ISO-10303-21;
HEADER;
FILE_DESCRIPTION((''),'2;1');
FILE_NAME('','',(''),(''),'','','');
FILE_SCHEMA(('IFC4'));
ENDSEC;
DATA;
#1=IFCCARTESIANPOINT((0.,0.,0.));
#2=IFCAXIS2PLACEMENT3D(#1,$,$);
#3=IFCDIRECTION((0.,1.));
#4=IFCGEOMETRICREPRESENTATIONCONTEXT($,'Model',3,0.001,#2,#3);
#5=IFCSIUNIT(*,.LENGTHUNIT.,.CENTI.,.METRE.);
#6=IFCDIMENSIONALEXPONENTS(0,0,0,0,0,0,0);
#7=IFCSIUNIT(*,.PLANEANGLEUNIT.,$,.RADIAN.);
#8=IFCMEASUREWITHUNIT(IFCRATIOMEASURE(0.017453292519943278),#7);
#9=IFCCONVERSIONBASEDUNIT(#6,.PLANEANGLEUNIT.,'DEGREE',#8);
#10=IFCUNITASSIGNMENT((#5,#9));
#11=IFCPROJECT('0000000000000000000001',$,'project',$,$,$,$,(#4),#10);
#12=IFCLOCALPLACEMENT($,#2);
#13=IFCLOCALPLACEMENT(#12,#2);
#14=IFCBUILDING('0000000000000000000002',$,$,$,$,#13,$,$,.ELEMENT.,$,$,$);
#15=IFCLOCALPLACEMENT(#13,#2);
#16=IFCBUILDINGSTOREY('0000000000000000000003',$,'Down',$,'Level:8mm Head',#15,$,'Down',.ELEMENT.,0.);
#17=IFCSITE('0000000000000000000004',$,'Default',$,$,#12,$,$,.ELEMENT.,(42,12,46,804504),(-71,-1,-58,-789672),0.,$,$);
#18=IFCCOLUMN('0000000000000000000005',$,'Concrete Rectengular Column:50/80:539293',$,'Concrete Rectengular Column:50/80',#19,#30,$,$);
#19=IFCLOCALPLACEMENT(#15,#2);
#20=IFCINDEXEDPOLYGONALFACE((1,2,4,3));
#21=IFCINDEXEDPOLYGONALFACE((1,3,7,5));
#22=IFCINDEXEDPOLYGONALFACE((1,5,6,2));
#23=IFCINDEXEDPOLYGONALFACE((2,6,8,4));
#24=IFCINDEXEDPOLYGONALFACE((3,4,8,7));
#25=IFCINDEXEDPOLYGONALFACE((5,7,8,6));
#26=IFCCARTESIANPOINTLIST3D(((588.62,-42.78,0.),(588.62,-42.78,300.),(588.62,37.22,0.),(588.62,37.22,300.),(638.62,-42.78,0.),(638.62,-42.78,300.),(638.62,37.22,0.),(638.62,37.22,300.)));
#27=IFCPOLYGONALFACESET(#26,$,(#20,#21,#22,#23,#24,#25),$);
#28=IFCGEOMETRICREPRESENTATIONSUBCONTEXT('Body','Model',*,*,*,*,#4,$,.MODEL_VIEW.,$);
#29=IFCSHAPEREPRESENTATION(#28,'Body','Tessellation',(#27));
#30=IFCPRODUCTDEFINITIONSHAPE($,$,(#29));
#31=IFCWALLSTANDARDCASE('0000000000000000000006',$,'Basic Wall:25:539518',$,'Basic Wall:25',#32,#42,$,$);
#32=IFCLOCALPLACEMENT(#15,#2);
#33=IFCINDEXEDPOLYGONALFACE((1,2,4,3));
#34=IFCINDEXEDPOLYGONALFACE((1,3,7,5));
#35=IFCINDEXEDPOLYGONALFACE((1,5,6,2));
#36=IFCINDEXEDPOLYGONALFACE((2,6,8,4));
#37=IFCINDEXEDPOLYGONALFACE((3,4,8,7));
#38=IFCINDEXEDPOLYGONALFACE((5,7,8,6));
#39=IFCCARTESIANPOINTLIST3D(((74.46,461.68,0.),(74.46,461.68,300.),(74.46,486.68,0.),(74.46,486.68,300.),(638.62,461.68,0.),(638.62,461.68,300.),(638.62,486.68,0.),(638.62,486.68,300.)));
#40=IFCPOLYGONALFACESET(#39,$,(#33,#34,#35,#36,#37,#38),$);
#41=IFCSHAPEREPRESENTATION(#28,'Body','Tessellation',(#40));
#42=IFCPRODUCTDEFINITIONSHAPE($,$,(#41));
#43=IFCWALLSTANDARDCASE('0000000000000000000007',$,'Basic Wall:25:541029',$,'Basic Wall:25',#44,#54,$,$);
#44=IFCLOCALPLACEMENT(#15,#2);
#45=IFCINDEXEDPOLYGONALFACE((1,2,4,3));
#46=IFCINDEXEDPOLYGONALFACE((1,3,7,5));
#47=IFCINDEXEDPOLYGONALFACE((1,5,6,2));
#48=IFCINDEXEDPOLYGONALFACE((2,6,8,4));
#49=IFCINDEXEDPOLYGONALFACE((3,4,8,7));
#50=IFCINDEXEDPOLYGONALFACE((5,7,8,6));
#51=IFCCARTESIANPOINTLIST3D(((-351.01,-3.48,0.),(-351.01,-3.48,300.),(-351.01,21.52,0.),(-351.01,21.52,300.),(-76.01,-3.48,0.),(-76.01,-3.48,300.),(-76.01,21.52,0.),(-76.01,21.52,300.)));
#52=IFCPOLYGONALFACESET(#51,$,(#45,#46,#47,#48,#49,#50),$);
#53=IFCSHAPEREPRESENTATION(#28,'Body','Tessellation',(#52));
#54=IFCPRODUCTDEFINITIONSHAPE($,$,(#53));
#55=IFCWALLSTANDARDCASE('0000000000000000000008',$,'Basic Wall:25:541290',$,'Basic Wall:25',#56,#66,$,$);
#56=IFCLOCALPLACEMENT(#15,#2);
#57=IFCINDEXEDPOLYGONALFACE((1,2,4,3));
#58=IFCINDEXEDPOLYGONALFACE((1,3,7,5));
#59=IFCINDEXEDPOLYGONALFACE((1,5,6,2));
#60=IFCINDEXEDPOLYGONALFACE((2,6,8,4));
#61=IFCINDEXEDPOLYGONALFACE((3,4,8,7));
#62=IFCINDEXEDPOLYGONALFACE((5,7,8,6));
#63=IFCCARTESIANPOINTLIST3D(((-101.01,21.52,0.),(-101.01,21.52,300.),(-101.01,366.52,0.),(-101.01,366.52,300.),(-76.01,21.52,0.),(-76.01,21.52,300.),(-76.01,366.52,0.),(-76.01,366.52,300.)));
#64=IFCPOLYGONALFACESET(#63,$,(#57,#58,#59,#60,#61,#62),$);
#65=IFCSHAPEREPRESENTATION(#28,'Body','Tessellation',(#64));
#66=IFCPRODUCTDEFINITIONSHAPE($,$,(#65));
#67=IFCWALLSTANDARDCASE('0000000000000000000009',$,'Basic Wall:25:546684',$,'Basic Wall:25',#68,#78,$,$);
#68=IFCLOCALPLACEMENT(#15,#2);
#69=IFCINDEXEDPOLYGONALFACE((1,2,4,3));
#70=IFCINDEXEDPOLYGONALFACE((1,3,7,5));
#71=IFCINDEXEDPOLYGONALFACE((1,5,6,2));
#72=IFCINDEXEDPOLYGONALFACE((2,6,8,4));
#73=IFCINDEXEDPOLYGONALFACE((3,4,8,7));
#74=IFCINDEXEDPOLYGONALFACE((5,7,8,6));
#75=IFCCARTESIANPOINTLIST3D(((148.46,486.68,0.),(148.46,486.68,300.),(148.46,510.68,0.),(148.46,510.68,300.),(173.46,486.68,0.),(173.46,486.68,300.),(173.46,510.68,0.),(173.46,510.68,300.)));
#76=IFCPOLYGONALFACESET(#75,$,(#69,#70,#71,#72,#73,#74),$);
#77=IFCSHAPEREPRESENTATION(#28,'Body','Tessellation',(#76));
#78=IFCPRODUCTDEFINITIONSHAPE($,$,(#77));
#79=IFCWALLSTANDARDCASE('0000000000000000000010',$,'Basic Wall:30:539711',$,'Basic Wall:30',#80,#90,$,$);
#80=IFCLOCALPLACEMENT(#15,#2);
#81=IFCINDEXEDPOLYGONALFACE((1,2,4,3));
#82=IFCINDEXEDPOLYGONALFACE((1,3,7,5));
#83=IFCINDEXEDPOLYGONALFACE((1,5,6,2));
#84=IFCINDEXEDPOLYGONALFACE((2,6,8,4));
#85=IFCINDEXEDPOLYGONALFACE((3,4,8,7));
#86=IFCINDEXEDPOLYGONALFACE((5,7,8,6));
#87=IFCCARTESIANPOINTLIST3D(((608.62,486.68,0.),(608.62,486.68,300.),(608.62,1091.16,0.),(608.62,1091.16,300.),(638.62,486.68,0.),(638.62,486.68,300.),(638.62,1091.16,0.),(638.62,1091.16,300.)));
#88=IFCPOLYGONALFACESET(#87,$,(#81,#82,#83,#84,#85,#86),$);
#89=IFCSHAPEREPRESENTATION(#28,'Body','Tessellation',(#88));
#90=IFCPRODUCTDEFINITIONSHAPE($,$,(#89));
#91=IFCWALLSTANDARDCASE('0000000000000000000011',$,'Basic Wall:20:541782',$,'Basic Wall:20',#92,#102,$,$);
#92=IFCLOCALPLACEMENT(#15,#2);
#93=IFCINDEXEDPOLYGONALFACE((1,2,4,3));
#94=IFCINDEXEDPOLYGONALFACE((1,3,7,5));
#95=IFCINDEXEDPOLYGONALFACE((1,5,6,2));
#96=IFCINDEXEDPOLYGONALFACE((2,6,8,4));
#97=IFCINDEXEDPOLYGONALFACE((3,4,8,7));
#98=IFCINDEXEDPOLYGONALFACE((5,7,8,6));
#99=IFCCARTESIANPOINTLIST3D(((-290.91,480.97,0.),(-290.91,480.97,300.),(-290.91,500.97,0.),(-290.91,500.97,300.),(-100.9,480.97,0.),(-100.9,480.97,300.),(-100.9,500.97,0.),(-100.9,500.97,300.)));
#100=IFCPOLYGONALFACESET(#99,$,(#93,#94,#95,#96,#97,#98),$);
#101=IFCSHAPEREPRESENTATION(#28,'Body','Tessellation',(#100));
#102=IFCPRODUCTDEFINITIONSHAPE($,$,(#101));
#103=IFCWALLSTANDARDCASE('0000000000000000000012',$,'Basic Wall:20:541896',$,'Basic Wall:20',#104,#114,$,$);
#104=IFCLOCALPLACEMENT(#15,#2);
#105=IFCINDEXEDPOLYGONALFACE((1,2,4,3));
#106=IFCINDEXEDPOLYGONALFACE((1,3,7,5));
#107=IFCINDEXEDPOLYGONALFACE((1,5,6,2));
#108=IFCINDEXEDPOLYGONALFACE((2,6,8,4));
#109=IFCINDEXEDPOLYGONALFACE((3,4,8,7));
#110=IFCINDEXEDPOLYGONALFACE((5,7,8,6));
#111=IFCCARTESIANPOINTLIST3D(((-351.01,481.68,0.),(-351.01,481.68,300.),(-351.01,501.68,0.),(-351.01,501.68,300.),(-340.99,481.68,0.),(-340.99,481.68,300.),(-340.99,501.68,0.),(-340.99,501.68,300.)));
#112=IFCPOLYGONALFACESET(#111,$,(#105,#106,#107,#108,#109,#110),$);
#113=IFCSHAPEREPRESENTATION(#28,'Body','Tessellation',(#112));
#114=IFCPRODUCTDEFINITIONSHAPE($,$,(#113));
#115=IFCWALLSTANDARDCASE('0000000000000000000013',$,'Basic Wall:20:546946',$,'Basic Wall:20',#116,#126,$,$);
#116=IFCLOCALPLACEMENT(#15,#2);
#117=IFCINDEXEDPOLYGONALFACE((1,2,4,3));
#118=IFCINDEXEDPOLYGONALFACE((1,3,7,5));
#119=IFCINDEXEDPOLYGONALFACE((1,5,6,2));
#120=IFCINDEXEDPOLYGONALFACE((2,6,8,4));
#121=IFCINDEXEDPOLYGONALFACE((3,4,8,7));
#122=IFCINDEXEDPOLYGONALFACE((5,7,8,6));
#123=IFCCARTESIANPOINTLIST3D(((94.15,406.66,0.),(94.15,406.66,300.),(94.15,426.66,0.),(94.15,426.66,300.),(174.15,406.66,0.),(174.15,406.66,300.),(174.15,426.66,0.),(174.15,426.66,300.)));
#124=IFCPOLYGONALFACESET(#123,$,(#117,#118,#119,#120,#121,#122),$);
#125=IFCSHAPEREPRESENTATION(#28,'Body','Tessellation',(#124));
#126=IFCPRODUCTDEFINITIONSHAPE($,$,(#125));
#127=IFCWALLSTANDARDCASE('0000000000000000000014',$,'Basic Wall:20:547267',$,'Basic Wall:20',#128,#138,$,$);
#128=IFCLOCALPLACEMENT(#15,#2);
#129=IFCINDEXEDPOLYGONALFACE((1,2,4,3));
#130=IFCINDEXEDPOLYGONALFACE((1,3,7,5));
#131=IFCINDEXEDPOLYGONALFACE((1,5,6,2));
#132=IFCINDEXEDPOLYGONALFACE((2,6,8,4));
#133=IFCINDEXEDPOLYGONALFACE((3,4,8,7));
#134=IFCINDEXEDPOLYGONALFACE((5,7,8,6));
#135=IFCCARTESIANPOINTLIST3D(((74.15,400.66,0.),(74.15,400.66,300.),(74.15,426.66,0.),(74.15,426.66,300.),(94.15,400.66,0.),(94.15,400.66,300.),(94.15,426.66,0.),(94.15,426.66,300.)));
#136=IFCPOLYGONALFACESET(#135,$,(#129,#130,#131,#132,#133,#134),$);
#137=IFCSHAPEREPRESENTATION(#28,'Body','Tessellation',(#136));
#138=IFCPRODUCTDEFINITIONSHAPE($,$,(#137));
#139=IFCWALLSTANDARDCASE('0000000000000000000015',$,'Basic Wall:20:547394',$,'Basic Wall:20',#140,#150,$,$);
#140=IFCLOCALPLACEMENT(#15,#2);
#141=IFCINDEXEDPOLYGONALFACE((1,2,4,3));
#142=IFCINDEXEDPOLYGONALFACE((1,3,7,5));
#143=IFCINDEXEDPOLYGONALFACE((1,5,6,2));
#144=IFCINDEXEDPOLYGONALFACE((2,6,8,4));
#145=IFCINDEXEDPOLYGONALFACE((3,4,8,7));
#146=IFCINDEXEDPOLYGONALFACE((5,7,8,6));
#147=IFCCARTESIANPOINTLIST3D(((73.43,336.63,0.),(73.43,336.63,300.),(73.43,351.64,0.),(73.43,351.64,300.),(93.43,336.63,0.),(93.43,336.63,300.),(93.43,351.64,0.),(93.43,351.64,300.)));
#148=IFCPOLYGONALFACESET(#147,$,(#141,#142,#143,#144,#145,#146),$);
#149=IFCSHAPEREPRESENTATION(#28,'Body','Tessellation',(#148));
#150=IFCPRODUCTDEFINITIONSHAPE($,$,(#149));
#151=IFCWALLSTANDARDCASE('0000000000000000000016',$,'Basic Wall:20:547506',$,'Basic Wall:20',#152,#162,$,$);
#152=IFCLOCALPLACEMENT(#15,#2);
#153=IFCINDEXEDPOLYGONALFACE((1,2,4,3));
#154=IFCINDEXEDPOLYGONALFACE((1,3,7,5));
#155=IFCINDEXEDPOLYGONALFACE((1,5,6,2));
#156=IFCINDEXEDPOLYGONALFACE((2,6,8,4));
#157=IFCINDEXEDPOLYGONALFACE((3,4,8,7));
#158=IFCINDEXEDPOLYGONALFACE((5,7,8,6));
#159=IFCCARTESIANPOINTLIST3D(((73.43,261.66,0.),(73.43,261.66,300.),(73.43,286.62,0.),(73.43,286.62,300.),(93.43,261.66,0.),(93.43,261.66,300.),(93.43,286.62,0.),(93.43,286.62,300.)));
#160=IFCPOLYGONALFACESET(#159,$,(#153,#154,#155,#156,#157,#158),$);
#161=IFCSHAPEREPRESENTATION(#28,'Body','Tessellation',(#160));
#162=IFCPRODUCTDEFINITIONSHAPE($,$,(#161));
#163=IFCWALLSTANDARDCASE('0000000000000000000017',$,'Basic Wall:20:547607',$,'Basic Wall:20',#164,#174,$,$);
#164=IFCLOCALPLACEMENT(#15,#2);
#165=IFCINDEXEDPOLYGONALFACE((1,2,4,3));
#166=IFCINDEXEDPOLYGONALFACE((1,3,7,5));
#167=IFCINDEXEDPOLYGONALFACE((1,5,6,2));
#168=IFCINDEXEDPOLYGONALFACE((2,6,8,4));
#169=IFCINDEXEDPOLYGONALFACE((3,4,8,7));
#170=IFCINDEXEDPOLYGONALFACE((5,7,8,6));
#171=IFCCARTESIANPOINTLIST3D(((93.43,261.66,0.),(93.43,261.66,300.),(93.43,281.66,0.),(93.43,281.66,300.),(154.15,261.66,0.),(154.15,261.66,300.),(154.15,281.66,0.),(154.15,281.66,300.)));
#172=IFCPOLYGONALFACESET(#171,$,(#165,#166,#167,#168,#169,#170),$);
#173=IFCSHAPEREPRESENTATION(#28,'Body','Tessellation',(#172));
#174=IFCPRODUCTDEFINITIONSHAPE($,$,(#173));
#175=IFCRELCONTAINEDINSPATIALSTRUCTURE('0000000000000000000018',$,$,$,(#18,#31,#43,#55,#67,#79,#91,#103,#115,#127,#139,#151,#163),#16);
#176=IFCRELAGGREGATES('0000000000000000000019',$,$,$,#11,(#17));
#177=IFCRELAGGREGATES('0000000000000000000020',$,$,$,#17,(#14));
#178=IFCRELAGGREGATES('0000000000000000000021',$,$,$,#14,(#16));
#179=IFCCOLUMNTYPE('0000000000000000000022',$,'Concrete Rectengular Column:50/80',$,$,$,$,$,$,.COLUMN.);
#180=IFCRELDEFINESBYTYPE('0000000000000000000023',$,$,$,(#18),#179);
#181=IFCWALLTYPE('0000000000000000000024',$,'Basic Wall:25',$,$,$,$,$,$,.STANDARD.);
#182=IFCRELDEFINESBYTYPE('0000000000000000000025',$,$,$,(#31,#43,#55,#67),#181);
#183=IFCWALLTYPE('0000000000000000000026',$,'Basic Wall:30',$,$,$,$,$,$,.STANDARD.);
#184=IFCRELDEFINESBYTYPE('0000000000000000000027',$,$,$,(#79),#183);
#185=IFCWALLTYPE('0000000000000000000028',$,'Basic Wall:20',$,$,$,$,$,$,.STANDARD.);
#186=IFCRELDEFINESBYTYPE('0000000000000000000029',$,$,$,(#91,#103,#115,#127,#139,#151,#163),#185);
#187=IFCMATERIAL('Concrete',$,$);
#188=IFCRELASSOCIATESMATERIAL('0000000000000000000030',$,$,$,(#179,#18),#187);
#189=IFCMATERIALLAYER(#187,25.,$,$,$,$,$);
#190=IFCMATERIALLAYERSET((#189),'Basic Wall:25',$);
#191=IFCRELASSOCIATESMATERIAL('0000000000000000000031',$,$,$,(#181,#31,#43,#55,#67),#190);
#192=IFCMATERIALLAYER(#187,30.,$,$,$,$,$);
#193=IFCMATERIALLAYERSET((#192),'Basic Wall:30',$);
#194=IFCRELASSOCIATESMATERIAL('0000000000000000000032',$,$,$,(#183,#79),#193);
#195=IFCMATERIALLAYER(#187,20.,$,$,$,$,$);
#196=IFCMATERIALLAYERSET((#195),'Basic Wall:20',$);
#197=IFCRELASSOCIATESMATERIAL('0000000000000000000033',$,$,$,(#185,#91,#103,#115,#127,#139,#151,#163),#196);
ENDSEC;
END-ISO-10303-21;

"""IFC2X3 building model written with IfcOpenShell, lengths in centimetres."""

from ifc_helpers import new_model, entity, si_unit, converted_unit, direction, frame, frame_2d, origin, place, context, subcontext, project, spatial, rectangle, extrude, source, transform, mapped, material, layer, layer_set, layer_usage, type_object, type_shapes, element, save


model = new_model("IFC2X3")

# Units and contexts
model_context = context("Model", 3, precision=0.001, world=origin(), true_north=direction((0.0, 1.0)))
body_context = subcontext(model_context, "Body", "Model", "MODEL_VIEW")
ifc_project = project(units=[si_unit("LENGTHUNIT", "METRE", prefix="CENTI"), converted_unit("PLANEANGLEUNIT", "DEGREE", entity("IfcRatioMeasure", 0.017453292519943278), si_unit("PLANEANGLEUNIT", "RADIAN"), dimensions=[0, 0, 0, 0, 0, 0, 0])], contexts=[model_context])

# Site, building, storey
site_placement = place(None, origin())
site = spatial("IfcSite", under=ifc_project, at=site_placement, Name="Default", CompositionType="ELEMENT", RefLatitude=(42, 12, 46, 804504), RefLongitude=(-71, -1, -58, -789672), RefElevation=0.0)
building_placement = place(site_placement, origin())
building = spatial("IfcBuilding", under=site, at=building_placement, CompositionType="ELEMENT")
storey_placement = place(building_placement, origin())
storey = spatial("IfcBuildingStorey", under=building, at=storey_placement, Name="Down", ObjectType="Level:8mm Head", LongName="Down", CompositionType="ELEMENT", Elevation=0.0)

# Column
ifc_material = material(Name="Concrete")
column_type_1 = type_object("IfcColumnType", Name="Concrete Rectengular Column:50/80", PredefinedType="COLUMN", material=ifc_material)
shared_shape_1 = source(origin(), body_context, "Body", "SweptSolid", [
    extrude(rectangle(XDim=80.0, YDim=50.0, at=frame_2d((0.0, 0.0), x_axis=(1.0, 0.0))), frame((613.62, -2.78, 0.0), z_axis=(0.0, 0.0, 1.0), x_axis=(0.0, -1.0, 0.0)), (0.0, 0.0, 1.0), 300.0),
])
type_shapes(column_type_1, [shared_shape_1])
column_1_placement = place(storey_placement, origin())
element("IfcColumn", 1, at=column_1_placement, inside=storey, type_object=column_type_1, material=ifc_material, Name="Concrete Rectengular Column:50/80:539293", ObjectType="Concrete Rectengular Column:50/80", context=body_context, shape_type="MappedRepresentation", body=[
    mapped(shared_shape_1, transform((0.0, 0.0, 0.0), scale=1.0)),
])

# Walls
ifc_layer_1 = layer(ifc_material, 25.0)
ifc_layer_set_1 = layer_set([ifc_layer_1], Name="Basic Wall:25")
ifc_layer_usage_1 = layer_usage(ifc_layer_set_1, "AXIS2", "POSITIVE", -12.5)
wall_type_1 = type_object("IfcWallType", Name="Basic Wall:25", PredefinedType="STANDARD", material=ifc_layer_set_1)
wall_1_placement = place(storey_placement, frame((74.46, 474.18, 0.0)))
element("IfcWallStandardCase", 2, at=wall_1_placement, inside=storey, type_object=wall_type_1, material=ifc_layer_usage_1, Name="Basic Wall:25:539518", ObjectType="Basic Wall:25", context=body_context, shape_type="SweptSolid", body=[
    extrude(rectangle(XDim=564.17, YDim=25.0, at=frame_2d((282.08, 0.0), x_axis=(-1.0, 0.0))), origin(), (0.0, 0.0, 1.0), 300.0),
])
ifc_layer_usage_2 = layer_usage(ifc_layer_set_1, "AXIS2", "POSITIVE", -12.5)
wall_2_placement = place(storey_placement, frame((-351.01, 9.02, 0.0)))
element("IfcWallStandardCase", 3, at=wall_2_placement, inside=storey, type_object=wall_type_1, material=ifc_layer_usage_2, Name="Basic Wall:25:541029", ObjectType="Basic Wall:25", context=body_context, shape_type="SweptSolid", body=[
    extrude(rectangle(XDim=275.0, YDim=25.0, at=frame_2d((137.5, 0.0), x_axis=(-1.0, 0.0))), origin(), (0.0, 0.0, 1.0), 300.0),
])
ifc_layer_usage_3 = layer_usage(ifc_layer_set_1, "AXIS2", "POSITIVE", -12.5)
wall_3_placement = place(storey_placement, frame((-88.51, 21.52, 0.0), z_axis=(0.0, 0.0, 1.0), x_axis=(0.0, 1.0, 0.0)))
element("IfcWallStandardCase", 4, at=wall_3_placement, inside=storey, type_object=wall_type_1, material=ifc_layer_usage_3, Name="Basic Wall:25:541290", ObjectType="Basic Wall:25", context=body_context, shape_type="SweptSolid", body=[
    extrude(rectangle(XDim=345.0, YDim=25.0, at=frame_2d((172.5, 0.0), x_axis=(-1.0, 0.0))), origin(), (0.0, 0.0, 1.0), 300.0),
])
ifc_layer_usage_4 = layer_usage(ifc_layer_set_1, "AXIS2", "NEGATIVE", 12.5)
wall_4_placement = place(storey_placement, frame((160.96, 486.68, 0.0), z_axis=(0.0, 0.0, 1.0), x_axis=(0.0, 1.0, 0.0)))
element("IfcWallStandardCase", 5, at=wall_4_placement, inside=storey, type_object=wall_type_1, material=ifc_layer_usage_4, Name="Basic Wall:25:546684", ObjectType="Basic Wall:25", context=body_context, shape_type="SweptSolid", body=[
    extrude(rectangle(XDim=24.01, YDim=25.0, at=frame_2d((12.0, 0.0), x_axis=(-1.0, 0.0))), origin(), (0.0, 0.0, 1.0), 300.0),
])
ifc_layer_2 = layer(ifc_material, 30.0)
ifc_layer_set_2 = layer_set([ifc_layer_2], Name="Basic Wall:30")
ifc_layer_usage_5 = layer_usage(ifc_layer_set_2, "AXIS2", "POSITIVE", -15.0)
wall_type_2 = type_object("IfcWallType", Name="Basic Wall:30", PredefinedType="STANDARD", material=ifc_layer_set_2)
wall_5_placement = place(storey_placement, frame((623.62, 486.68, 0.0), z_axis=(0.0, 0.0, 1.0), x_axis=(0.0, 1.0, 0.0)))
element("IfcWallStandardCase", 6, at=wall_5_placement, inside=storey, type_object=wall_type_2, material=ifc_layer_usage_5, Name="Basic Wall:30:539711", ObjectType="Basic Wall:30", context=body_context, shape_type="SweptSolid", body=[
    extrude(rectangle(XDim=604.48, YDim=30.0, at=frame_2d((302.24, 0.0), x_axis=(-1.0, 0.0))), origin(), (0.0, 0.0, 1.0), 300.0),
])
ifc_layer_3 = layer(ifc_material, 20.0)
ifc_layer_set_3 = layer_set([ifc_layer_3], Name="Basic Wall:20")
ifc_layer_usage_6 = layer_usage(ifc_layer_set_3, "AXIS2", "NEGATIVE", 10.0)
wall_type_3 = type_object("IfcWallType", Name="Basic Wall:20", PredefinedType="STANDARD", material=ifc_layer_set_3)
wall_6_placement = place(storey_placement, frame((-100.9, 490.97, 0.0), z_axis=(0.0, 0.0, 1.0), x_axis=(-1.0, 0.0, 0.0)))
element("IfcWallStandardCase", 7, at=wall_6_placement, inside=storey, type_object=wall_type_3, material=ifc_layer_usage_6, Name="Basic Wall:20:541782", ObjectType="Basic Wall:20", context=body_context, shape_type="SweptSolid", body=[
    extrude(rectangle(XDim=190.01, YDim=20.0, at=frame_2d((95.0, 0.0), x_axis=(-1.0, 0.0))), origin(), (0.0, 0.0, 1.0), 300.0),
])
ifc_layer_usage_7 = layer_usage(ifc_layer_set_3, "AXIS2", "NEGATIVE", 10.0)
wall_7_placement = place(storey_placement, frame((-340.99, 491.68, 0.0), z_axis=(0.0, 0.0, 1.0), x_axis=(-1.0, 0.0, 0.0)))
element("IfcWallStandardCase", 8, at=wall_7_placement, inside=storey, type_object=wall_type_3, material=ifc_layer_usage_7, Name="Basic Wall:20:541896", ObjectType="Basic Wall:20", context=body_context, shape_type="SweptSolid", body=[
    extrude(rectangle(XDim=10.01, YDim=20.0, at=frame_2d((5.01, 0.0), x_axis=(-1.0, 0.0))), origin(), (0.0, 0.0, 1.0), 300.0),
])
ifc_layer_usage_8 = layer_usage(ifc_layer_set_3, "AXIS2", "NEGATIVE", 10.0)
wall_8_placement = place(storey_placement, frame((94.15, 416.66, 0.0)))
element("IfcWallStandardCase", 9, at=wall_8_placement, inside=storey, type_object=wall_type_3, material=ifc_layer_usage_8, Name="Basic Wall:20:546946", ObjectType="Basic Wall:20", context=body_context, shape_type="SweptSolid", body=[
    extrude(rectangle(XDim=80.0, YDim=20.0, at=frame_2d((40.0, 0.0), x_axis=(-1.0, 0.0))), origin(), (0.0, 0.0, 1.0), 300.0),
])
ifc_layer_usage_9 = layer_usage(ifc_layer_set_3, "AXIS2", "POSITIVE", -10.0)
wall_9_placement = place(storey_placement, frame((84.15, 426.66, 0.0), z_axis=(0.0, 0.0, 1.0), x_axis=(0.0, -1.0, 0.0)))
element("IfcWallStandardCase", 10, at=wall_9_placement, inside=storey, type_object=wall_type_3, material=ifc_layer_usage_9, Name="Basic Wall:20:547267", ObjectType="Basic Wall:20", context=body_context, shape_type="SweptSolid", body=[
    extrude(rectangle(XDim=26.0, YDim=20.0, at=frame_2d((13.0, 0.0), x_axis=(-1.0, 0.0))), origin(), (0.0, 0.0, 1.0), 300.0),
])
ifc_layer_usage_10 = layer_usage(ifc_layer_set_3, "AXIS2", "POSITIVE", -10.0)
wall_10_placement = place(storey_placement, frame((83.43, 351.64, 0.0), z_axis=(0.0, 0.0, 1.0), x_axis=(0.0, -1.0, 0.0)))
element("IfcWallStandardCase", 11, at=wall_10_placement, inside=storey, type_object=wall_type_3, material=ifc_layer_usage_10, Name="Basic Wall:20:547394", ObjectType="Basic Wall:20", context=body_context, shape_type="SweptSolid", body=[
    extrude(rectangle(XDim=15.01, YDim=20.0, at=frame_2d((7.5, 0.0), x_axis=(-1.0, 0.0))), origin(), (0.0, 0.0, 1.0), 300.0),
])
ifc_layer_usage_11 = layer_usage(ifc_layer_set_3, "AXIS2", "POSITIVE", -10.0)
wall_11_placement = place(storey_placement, frame((83.43, 286.62, 0.0), z_axis=(0.0, 0.0, 1.0), x_axis=(0.0, -1.0, 0.0)))
element("IfcWallStandardCase", 12, at=wall_11_placement, inside=storey, type_object=wall_type_3, material=ifc_layer_usage_11, Name="Basic Wall:20:547506", ObjectType="Basic Wall:20", context=body_context, shape_type="SweptSolid", body=[
    extrude(rectangle(XDim=24.95, YDim=20.0, at=frame_2d((12.48, 0.0), x_axis=(-1.0, 0.0))), origin(), (0.0, 0.0, 1.0), 300.0),
])
ifc_layer_usage_12 = layer_usage(ifc_layer_set_3, "AXIS2", "POSITIVE", -10.0)
wall_12_placement = place(storey_placement, frame((93.43, 271.66, 0.0)))
element("IfcWallStandardCase", 13, at=wall_12_placement, inside=storey, type_object=wall_type_3, material=ifc_layer_usage_12, Name="Basic Wall:20:547607", ObjectType="Basic Wall:20", context=body_context, shape_type="SweptSolid", body=[
    extrude(rectangle(XDim=60.71, YDim=20.0, at=frame_2d((30.36, 0.0), x_axis=(-1.0, 0.0))), origin(), (0.0, 0.0, 1.0), 300.0),
])

save(model, "model.ifc")
